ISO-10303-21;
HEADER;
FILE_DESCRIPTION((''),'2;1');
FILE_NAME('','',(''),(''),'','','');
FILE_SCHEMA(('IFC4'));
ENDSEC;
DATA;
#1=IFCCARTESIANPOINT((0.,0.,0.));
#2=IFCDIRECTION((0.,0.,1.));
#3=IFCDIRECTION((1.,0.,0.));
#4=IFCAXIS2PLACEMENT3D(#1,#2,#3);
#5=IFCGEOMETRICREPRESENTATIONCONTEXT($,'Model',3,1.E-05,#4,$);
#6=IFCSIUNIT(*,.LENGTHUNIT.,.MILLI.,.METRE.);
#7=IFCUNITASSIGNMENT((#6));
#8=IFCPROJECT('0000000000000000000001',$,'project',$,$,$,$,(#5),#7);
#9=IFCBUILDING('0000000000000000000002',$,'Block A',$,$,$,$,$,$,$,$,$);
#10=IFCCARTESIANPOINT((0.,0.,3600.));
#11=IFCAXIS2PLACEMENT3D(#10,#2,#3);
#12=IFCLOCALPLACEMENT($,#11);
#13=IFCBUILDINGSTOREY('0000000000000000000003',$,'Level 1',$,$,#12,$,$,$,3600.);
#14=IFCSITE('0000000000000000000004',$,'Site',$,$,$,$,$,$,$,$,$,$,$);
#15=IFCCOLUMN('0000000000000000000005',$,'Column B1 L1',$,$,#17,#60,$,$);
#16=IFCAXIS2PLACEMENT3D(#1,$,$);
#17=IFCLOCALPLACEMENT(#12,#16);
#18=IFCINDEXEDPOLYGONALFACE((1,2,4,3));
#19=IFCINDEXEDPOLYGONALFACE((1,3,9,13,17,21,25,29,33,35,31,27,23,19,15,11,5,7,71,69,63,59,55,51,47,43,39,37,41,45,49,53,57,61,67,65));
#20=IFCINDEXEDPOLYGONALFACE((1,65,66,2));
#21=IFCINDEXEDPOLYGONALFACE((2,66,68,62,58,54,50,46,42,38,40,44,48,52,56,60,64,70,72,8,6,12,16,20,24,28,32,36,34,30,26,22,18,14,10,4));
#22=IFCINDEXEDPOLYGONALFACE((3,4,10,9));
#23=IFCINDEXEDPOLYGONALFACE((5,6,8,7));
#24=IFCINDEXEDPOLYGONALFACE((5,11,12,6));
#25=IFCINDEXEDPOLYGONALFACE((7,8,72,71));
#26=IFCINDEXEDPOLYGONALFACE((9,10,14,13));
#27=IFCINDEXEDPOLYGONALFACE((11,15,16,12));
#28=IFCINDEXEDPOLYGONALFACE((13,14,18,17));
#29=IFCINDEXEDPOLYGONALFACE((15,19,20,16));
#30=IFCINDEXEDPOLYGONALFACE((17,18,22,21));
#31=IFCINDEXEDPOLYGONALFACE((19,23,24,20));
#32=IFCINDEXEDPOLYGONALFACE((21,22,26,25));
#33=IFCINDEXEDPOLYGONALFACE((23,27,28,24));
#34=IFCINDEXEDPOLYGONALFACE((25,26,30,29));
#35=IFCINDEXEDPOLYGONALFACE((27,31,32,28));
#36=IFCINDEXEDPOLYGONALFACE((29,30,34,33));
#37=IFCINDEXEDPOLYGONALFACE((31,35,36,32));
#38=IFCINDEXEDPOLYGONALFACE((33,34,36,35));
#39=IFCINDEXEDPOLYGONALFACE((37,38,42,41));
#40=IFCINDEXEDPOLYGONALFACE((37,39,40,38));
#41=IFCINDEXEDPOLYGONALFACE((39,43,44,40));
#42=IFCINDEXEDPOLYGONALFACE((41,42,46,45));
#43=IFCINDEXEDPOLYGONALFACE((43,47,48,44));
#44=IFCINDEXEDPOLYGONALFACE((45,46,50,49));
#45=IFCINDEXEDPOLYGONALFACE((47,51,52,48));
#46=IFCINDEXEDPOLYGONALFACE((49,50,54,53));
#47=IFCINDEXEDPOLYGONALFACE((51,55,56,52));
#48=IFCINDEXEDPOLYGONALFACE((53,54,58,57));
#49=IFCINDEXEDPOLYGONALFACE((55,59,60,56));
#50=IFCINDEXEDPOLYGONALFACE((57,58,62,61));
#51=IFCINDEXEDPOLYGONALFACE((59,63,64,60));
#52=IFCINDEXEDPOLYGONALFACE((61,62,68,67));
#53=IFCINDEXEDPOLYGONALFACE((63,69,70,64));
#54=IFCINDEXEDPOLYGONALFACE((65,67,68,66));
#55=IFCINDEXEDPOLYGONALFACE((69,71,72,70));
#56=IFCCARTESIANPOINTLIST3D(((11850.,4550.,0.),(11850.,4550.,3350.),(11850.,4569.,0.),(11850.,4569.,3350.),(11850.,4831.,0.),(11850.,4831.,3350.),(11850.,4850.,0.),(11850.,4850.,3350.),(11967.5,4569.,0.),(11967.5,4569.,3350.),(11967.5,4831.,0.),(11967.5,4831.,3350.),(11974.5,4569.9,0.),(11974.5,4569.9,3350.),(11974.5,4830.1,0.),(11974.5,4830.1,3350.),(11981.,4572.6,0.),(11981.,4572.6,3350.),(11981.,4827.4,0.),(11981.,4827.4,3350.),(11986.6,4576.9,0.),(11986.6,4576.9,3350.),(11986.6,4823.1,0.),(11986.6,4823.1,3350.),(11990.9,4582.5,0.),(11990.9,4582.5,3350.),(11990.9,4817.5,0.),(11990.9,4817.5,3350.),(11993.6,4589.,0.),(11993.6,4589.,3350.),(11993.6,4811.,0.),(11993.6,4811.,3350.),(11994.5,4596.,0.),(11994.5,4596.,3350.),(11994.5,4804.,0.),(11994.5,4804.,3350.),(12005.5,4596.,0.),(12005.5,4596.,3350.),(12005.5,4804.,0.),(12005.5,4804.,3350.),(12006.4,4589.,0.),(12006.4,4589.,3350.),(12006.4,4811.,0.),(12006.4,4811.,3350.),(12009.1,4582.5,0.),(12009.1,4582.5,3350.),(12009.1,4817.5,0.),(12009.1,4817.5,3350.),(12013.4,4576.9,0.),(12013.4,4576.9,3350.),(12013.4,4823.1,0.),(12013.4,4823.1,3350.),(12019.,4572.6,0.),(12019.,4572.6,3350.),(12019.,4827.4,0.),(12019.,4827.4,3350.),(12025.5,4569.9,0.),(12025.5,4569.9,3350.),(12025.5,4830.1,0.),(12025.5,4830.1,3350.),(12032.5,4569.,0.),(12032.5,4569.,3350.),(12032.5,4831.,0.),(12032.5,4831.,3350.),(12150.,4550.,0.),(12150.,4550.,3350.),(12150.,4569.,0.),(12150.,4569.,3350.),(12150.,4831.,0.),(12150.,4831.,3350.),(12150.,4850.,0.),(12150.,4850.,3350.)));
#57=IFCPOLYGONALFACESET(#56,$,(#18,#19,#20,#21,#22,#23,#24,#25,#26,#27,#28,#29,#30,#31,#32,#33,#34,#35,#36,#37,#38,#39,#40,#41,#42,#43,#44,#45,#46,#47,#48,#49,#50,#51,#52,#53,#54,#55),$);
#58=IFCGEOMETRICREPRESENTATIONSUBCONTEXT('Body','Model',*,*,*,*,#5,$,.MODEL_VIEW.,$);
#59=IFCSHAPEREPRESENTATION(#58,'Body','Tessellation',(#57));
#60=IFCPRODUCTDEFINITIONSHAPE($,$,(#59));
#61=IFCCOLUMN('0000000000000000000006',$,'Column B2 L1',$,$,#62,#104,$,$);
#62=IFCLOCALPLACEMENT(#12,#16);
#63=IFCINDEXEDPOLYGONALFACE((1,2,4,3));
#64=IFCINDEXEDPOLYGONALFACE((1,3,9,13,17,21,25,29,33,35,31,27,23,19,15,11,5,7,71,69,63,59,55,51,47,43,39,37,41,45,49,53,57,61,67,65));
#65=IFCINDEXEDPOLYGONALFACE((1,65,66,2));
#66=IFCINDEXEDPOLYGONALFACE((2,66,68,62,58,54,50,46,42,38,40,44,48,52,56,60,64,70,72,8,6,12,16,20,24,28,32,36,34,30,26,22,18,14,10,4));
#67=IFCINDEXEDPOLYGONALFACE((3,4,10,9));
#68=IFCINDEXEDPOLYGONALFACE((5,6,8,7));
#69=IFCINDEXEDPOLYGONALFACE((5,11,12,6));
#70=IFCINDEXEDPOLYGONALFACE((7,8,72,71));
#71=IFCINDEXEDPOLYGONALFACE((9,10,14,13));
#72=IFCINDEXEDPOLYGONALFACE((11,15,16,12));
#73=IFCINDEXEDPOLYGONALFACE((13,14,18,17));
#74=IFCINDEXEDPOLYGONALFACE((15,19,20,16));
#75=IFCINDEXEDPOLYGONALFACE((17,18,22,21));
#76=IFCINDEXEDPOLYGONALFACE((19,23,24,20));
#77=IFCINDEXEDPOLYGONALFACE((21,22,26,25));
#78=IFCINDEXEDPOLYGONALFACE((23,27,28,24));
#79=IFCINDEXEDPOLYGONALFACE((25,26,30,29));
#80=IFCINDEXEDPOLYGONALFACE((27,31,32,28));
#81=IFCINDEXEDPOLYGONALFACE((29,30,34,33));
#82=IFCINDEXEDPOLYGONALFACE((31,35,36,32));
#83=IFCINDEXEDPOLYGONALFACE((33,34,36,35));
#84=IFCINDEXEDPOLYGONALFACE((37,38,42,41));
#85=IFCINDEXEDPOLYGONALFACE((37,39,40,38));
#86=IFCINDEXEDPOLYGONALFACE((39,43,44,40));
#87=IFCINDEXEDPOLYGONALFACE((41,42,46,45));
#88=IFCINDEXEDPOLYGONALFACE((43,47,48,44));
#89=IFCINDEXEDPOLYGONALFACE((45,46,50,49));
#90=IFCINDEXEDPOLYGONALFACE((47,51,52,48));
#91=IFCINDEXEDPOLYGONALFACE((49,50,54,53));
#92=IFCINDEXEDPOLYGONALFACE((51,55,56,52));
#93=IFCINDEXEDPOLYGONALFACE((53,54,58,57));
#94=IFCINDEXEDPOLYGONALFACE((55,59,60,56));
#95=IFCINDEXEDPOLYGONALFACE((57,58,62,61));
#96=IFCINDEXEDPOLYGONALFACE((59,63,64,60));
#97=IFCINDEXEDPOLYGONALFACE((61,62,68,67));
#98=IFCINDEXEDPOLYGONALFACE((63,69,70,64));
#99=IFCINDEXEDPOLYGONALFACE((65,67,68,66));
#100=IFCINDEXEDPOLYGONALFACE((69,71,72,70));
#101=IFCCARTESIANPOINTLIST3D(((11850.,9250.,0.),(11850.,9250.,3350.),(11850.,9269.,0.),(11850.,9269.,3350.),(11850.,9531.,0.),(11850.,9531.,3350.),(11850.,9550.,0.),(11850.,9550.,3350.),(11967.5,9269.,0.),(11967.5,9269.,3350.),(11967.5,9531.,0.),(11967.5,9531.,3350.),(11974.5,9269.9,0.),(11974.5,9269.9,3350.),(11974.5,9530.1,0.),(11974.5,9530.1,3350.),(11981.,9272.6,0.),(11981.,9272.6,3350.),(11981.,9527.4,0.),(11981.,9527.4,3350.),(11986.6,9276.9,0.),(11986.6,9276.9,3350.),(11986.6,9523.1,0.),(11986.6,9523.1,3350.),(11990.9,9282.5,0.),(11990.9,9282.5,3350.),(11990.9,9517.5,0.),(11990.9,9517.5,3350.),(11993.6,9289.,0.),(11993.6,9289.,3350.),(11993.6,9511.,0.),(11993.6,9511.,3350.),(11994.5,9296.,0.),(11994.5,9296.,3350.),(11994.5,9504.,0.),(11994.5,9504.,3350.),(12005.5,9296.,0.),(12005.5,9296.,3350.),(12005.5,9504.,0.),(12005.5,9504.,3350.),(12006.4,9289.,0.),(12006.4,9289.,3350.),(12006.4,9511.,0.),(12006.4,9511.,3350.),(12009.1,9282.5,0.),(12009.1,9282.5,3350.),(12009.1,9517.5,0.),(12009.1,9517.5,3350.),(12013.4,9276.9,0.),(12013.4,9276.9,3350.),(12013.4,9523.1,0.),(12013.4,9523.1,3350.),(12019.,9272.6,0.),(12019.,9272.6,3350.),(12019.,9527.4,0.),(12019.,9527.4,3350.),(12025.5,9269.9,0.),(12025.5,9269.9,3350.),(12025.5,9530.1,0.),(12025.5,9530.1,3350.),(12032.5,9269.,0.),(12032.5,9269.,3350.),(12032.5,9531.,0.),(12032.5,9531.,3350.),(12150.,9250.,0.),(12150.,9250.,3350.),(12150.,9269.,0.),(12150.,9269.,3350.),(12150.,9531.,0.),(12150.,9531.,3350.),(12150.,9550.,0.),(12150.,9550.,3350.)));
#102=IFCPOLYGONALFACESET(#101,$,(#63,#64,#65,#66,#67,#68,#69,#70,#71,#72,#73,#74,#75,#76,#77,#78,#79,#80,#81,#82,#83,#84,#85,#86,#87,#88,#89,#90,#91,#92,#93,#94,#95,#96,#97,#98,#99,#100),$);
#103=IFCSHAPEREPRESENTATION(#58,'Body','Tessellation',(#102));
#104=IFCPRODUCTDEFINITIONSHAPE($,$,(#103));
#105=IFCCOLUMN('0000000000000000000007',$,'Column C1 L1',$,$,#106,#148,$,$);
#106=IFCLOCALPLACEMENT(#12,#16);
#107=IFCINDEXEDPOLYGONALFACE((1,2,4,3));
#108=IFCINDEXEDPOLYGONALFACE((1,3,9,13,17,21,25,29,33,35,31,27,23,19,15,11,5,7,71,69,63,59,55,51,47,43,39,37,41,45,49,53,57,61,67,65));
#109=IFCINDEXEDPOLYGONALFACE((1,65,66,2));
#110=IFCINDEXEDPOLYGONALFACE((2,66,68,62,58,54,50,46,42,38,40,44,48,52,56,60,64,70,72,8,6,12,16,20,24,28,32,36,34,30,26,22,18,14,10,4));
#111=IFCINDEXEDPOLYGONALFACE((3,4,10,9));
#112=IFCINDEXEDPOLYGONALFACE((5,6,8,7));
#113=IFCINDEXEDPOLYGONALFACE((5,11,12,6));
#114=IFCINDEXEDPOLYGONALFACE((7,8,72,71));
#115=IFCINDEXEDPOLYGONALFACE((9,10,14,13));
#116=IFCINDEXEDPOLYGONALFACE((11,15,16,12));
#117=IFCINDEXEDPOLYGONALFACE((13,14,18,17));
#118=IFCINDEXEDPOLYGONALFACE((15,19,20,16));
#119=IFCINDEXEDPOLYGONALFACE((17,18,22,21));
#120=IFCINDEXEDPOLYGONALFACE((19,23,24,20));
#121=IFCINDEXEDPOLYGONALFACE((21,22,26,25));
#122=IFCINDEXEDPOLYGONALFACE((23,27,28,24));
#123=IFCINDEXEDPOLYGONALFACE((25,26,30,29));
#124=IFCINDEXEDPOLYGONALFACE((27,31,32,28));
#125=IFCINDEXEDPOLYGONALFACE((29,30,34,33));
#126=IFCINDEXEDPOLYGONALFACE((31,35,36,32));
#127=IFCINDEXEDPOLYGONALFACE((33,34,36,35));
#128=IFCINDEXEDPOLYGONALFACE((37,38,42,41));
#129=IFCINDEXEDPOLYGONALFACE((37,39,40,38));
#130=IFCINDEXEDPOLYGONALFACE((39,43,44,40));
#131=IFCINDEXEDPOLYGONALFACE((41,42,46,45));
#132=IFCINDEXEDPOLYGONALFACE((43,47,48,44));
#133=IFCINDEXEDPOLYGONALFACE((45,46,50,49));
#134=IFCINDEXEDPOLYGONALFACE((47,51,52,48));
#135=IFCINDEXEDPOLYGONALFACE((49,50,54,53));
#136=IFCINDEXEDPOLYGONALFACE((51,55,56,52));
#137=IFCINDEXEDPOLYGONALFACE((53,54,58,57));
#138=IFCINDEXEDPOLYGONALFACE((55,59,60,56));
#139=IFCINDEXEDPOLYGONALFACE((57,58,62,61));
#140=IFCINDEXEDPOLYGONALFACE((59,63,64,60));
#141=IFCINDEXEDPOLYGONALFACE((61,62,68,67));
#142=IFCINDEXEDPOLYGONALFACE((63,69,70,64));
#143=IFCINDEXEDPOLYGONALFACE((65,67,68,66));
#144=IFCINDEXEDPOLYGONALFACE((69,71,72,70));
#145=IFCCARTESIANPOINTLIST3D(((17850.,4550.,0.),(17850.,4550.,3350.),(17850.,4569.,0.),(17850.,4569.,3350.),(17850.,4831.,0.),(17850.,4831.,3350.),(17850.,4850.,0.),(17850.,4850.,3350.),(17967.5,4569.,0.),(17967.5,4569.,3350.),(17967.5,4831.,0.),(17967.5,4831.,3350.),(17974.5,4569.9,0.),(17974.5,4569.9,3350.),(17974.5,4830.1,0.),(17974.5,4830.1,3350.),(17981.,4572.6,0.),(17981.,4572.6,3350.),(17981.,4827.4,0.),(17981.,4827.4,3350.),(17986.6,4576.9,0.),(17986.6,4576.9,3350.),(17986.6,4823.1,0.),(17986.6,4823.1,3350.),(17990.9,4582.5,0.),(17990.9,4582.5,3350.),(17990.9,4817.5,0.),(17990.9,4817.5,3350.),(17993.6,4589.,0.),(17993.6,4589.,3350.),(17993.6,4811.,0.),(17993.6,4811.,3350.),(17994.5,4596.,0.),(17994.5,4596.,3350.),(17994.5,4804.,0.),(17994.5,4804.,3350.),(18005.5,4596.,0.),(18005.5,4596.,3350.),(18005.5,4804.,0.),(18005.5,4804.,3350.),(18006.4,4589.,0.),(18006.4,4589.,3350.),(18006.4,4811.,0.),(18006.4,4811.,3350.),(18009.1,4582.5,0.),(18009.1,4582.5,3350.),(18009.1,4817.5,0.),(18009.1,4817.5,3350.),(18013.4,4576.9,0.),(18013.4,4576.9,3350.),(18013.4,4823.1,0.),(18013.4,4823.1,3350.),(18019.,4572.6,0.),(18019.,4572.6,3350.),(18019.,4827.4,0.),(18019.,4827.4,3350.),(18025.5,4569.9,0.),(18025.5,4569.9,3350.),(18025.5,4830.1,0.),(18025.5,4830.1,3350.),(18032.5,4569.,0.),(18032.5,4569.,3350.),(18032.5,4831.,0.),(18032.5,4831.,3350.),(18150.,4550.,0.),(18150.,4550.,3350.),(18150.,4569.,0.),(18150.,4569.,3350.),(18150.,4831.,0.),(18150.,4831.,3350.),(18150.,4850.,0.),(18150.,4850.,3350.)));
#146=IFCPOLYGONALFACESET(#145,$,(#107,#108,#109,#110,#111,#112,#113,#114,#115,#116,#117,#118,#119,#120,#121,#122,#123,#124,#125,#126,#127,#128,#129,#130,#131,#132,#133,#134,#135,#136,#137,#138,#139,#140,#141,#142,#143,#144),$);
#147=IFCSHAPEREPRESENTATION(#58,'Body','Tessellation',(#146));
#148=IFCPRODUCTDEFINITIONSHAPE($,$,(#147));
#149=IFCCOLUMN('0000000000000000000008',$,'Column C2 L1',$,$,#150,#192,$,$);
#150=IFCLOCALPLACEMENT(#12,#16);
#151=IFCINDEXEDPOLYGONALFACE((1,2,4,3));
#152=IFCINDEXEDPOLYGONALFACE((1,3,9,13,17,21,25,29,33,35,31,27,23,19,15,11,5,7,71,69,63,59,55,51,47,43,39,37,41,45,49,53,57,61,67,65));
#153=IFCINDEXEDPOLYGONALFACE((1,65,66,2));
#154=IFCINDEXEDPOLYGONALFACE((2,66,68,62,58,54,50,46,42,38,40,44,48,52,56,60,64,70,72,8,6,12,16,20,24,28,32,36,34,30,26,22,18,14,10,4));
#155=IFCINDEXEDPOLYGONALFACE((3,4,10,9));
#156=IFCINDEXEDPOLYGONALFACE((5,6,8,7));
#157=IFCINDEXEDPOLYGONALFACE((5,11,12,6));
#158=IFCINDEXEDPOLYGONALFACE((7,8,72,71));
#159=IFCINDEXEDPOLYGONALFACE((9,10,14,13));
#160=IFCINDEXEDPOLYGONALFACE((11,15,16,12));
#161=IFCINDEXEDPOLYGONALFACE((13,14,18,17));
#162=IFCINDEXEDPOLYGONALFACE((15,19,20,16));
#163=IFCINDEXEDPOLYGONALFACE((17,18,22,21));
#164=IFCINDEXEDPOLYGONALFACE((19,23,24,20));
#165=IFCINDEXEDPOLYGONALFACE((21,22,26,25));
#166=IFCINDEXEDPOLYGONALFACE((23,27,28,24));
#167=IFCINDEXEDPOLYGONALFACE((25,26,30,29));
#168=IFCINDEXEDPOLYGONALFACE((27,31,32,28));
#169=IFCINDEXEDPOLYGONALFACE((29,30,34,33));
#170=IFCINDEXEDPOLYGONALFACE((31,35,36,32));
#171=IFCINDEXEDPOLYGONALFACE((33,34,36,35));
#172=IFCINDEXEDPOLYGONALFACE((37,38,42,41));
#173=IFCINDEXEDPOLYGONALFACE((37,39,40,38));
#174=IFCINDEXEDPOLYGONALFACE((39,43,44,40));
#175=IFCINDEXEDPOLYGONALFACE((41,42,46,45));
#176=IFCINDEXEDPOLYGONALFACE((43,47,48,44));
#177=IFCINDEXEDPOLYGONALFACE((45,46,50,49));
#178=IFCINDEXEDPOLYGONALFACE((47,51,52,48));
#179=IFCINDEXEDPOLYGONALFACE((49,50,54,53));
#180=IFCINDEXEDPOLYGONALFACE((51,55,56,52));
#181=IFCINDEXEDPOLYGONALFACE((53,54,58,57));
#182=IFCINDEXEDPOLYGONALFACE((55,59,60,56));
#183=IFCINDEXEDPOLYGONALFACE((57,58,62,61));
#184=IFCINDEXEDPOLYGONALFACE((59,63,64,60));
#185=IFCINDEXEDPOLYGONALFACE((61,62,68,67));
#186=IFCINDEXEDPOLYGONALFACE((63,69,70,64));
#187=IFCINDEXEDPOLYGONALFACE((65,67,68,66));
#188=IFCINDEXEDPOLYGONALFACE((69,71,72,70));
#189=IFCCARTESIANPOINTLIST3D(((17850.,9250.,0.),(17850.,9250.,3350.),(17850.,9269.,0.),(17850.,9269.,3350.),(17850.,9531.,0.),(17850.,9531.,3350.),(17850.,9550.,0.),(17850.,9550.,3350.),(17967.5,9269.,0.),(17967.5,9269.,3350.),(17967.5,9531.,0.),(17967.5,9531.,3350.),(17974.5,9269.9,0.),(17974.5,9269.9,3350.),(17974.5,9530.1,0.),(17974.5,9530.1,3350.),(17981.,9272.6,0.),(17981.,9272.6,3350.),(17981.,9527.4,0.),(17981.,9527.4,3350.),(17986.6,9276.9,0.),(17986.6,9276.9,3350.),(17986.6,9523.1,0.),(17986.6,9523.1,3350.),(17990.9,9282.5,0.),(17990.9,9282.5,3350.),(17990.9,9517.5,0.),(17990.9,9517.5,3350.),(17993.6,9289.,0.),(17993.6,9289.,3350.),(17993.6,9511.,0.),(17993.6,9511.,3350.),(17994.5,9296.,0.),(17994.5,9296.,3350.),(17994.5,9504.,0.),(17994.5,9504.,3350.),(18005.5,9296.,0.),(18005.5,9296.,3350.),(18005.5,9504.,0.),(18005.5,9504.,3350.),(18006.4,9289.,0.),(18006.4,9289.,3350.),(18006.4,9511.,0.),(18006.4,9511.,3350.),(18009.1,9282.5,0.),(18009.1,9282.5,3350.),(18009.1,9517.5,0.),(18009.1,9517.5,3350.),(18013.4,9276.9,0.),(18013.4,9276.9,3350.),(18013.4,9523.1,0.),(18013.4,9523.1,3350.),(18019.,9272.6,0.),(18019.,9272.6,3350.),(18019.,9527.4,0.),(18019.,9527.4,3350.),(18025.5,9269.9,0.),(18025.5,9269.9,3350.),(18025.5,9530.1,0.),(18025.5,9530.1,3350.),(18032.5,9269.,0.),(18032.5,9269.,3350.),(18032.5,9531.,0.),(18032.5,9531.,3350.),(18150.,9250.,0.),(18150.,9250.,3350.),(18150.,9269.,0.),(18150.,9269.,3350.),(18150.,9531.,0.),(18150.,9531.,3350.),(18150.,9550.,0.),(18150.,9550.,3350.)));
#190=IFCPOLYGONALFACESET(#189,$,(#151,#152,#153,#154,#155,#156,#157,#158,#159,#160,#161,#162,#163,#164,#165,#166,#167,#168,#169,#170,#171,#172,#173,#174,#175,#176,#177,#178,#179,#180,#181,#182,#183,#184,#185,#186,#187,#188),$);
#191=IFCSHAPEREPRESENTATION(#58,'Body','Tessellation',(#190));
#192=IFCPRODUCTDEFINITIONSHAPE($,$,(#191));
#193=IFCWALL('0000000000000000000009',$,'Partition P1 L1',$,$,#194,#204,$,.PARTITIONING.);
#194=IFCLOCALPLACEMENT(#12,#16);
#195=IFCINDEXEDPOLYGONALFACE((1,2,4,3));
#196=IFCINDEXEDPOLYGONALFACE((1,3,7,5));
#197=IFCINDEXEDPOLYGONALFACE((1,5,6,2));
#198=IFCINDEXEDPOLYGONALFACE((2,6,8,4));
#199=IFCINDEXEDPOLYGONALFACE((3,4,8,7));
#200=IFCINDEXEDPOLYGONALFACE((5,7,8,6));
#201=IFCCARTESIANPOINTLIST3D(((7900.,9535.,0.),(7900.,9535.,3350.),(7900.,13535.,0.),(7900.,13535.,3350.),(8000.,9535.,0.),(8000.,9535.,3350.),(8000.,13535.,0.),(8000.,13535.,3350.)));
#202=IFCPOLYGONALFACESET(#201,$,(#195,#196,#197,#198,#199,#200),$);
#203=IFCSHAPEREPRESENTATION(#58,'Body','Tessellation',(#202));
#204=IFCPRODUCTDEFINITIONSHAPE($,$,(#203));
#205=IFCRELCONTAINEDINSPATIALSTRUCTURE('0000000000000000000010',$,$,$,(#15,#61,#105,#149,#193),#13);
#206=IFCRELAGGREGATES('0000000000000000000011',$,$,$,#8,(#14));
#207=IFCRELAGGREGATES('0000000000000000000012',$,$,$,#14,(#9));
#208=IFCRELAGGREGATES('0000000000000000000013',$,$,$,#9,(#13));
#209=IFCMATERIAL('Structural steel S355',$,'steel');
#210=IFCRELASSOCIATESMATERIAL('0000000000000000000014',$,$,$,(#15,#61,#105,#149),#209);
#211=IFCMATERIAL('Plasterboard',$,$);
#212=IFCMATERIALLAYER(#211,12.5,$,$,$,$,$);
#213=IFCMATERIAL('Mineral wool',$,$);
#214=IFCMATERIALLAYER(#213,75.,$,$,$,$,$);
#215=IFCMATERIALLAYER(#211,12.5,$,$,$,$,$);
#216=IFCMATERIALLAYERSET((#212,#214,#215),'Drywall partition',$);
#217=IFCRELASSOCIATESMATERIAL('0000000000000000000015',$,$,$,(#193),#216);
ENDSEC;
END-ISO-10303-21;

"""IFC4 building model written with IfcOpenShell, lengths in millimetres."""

from ifc_helpers import new_model, si_unit, frame, origin_with_axes, place, context, subcontext, project, spatial, indexed_curve, i_section, outline, extrude, material, layer, layer_set, layer_usage, material_profile, profile_set, element, save


model = new_model("IFC4")

# Units and contexts
model_context = context("Model", 3, precision=1e-05, world=origin_with_axes())
body_context = subcontext(model_context, "Body", "Model", "MODEL_VIEW")
ifc_project = project(units=[si_unit("LENGTHUNIT", "METRE", prefix="MILLI")], contexts=[model_context])

# Site, building, storey
site = spatial("IfcSite", under=ifc_project, Name="Site")
building = spatial("IfcBuilding", under=site, Name="Block A")
storey_placement = place(None, frame((0.0, 0.0, 3600.0), z_axis=(0.0, 0.0, 1.0), x_axis=(1.0, 0.0, 0.0)))
storey = spatial("IfcBuildingStorey", under=building, at=storey_placement, Name="Level 1", Elevation=3600.0)

# Columns
ifc_material_1 = material(Name="Structural steel S355", Category="steel")
ifc_material_profile = material_profile(ifc_material_1, i_section(OverallWidth=300.0, OverallDepth=300.0, WebThickness=11.0, FlangeThickness=19.0, FilletRadius=27.0))
ifc_profile_set = profile_set([ifc_material_profile], Name="HEB 300")
for number, where, z_axis, x_axis, name in (
    (1, (12000.0, 4700.0, 0.0), (0.0, 0.0, 1.0), (1.0, 0.0, 0.0), "Column B1 L1"),
    (2, (12000.0, 9400.0, 0.0), (0.0, 0.0, 1.0), (1.0, 0.0, 0.0), "Column B2 L1"),
    (3, (18000.0, 4700.0, 0.0), (0.0, 0.0, 1.0), (1.0, 0.0, 0.0), "Column C1 L1"),
    (4, (18000.0, 9400.0, 0.0), (0.0, 0.0, 1.0), (1.0, 0.0, 0.0), "Column C2 L1"),
):
    element("IfcColumn", number, at=place(storey_placement, frame(where, z_axis=z_axis, x_axis=x_axis)), inside=storey, material=ifc_profile_set, Name=name, context=body_context, shape_type="SweptSolid", body=[
        extrude(i_section(OverallWidth=300.0, OverallDepth=300.0, WebThickness=11.0, FlangeThickness=19.0, FilletRadius=27.0), origin_with_axes(), (0.0, 0.0, 1.0), 3350.0),
    ])

# Shared definitions
ifc_material_2 = material(Name="Mineral wool")

# Wall
ifc_material_3 = material(Name="Plasterboard")
ifc_layer_1 = layer(ifc_material_3, 12.5)
ifc_layer_2 = layer(ifc_material_2, 75.0)
ifc_layer_3 = layer(ifc_material_3, 12.5)
ifc_layer_set_1 = layer_set([ifc_layer_1, ifc_layer_2, ifc_layer_3], Name="Drywall partition")
ifc_layer_usage_1 = layer_usage(ifc_layer_set_1, "AXIS2", "POSITIVE", 0.0)
wall_1_placement = place(storey_placement, frame((8000.0, 9535.0, 0.0), z_axis=(0.0, 0.0, 1.0), x_axis=(0.0, 1.0, 0.0)))
element("IfcWall", 5, at=wall_1_placement, inside=storey, material=ifc_layer_usage_1, Name="Partition P1 L1", PredefinedType="PARTITIONING", context=body_context, shape_type="SweptSolid", body=[
    extrude(outline(indexed_curve([(0.0, 0.0), (0.0, 100.0), (4000.0, 100.0), (4000.0, 0.0), (0.0, 0.0)], self_intersect=False)), origin_with_axes(), (0.0, 0.0, 1.0), 3350.0),
])

save(model, "model.ifc")
